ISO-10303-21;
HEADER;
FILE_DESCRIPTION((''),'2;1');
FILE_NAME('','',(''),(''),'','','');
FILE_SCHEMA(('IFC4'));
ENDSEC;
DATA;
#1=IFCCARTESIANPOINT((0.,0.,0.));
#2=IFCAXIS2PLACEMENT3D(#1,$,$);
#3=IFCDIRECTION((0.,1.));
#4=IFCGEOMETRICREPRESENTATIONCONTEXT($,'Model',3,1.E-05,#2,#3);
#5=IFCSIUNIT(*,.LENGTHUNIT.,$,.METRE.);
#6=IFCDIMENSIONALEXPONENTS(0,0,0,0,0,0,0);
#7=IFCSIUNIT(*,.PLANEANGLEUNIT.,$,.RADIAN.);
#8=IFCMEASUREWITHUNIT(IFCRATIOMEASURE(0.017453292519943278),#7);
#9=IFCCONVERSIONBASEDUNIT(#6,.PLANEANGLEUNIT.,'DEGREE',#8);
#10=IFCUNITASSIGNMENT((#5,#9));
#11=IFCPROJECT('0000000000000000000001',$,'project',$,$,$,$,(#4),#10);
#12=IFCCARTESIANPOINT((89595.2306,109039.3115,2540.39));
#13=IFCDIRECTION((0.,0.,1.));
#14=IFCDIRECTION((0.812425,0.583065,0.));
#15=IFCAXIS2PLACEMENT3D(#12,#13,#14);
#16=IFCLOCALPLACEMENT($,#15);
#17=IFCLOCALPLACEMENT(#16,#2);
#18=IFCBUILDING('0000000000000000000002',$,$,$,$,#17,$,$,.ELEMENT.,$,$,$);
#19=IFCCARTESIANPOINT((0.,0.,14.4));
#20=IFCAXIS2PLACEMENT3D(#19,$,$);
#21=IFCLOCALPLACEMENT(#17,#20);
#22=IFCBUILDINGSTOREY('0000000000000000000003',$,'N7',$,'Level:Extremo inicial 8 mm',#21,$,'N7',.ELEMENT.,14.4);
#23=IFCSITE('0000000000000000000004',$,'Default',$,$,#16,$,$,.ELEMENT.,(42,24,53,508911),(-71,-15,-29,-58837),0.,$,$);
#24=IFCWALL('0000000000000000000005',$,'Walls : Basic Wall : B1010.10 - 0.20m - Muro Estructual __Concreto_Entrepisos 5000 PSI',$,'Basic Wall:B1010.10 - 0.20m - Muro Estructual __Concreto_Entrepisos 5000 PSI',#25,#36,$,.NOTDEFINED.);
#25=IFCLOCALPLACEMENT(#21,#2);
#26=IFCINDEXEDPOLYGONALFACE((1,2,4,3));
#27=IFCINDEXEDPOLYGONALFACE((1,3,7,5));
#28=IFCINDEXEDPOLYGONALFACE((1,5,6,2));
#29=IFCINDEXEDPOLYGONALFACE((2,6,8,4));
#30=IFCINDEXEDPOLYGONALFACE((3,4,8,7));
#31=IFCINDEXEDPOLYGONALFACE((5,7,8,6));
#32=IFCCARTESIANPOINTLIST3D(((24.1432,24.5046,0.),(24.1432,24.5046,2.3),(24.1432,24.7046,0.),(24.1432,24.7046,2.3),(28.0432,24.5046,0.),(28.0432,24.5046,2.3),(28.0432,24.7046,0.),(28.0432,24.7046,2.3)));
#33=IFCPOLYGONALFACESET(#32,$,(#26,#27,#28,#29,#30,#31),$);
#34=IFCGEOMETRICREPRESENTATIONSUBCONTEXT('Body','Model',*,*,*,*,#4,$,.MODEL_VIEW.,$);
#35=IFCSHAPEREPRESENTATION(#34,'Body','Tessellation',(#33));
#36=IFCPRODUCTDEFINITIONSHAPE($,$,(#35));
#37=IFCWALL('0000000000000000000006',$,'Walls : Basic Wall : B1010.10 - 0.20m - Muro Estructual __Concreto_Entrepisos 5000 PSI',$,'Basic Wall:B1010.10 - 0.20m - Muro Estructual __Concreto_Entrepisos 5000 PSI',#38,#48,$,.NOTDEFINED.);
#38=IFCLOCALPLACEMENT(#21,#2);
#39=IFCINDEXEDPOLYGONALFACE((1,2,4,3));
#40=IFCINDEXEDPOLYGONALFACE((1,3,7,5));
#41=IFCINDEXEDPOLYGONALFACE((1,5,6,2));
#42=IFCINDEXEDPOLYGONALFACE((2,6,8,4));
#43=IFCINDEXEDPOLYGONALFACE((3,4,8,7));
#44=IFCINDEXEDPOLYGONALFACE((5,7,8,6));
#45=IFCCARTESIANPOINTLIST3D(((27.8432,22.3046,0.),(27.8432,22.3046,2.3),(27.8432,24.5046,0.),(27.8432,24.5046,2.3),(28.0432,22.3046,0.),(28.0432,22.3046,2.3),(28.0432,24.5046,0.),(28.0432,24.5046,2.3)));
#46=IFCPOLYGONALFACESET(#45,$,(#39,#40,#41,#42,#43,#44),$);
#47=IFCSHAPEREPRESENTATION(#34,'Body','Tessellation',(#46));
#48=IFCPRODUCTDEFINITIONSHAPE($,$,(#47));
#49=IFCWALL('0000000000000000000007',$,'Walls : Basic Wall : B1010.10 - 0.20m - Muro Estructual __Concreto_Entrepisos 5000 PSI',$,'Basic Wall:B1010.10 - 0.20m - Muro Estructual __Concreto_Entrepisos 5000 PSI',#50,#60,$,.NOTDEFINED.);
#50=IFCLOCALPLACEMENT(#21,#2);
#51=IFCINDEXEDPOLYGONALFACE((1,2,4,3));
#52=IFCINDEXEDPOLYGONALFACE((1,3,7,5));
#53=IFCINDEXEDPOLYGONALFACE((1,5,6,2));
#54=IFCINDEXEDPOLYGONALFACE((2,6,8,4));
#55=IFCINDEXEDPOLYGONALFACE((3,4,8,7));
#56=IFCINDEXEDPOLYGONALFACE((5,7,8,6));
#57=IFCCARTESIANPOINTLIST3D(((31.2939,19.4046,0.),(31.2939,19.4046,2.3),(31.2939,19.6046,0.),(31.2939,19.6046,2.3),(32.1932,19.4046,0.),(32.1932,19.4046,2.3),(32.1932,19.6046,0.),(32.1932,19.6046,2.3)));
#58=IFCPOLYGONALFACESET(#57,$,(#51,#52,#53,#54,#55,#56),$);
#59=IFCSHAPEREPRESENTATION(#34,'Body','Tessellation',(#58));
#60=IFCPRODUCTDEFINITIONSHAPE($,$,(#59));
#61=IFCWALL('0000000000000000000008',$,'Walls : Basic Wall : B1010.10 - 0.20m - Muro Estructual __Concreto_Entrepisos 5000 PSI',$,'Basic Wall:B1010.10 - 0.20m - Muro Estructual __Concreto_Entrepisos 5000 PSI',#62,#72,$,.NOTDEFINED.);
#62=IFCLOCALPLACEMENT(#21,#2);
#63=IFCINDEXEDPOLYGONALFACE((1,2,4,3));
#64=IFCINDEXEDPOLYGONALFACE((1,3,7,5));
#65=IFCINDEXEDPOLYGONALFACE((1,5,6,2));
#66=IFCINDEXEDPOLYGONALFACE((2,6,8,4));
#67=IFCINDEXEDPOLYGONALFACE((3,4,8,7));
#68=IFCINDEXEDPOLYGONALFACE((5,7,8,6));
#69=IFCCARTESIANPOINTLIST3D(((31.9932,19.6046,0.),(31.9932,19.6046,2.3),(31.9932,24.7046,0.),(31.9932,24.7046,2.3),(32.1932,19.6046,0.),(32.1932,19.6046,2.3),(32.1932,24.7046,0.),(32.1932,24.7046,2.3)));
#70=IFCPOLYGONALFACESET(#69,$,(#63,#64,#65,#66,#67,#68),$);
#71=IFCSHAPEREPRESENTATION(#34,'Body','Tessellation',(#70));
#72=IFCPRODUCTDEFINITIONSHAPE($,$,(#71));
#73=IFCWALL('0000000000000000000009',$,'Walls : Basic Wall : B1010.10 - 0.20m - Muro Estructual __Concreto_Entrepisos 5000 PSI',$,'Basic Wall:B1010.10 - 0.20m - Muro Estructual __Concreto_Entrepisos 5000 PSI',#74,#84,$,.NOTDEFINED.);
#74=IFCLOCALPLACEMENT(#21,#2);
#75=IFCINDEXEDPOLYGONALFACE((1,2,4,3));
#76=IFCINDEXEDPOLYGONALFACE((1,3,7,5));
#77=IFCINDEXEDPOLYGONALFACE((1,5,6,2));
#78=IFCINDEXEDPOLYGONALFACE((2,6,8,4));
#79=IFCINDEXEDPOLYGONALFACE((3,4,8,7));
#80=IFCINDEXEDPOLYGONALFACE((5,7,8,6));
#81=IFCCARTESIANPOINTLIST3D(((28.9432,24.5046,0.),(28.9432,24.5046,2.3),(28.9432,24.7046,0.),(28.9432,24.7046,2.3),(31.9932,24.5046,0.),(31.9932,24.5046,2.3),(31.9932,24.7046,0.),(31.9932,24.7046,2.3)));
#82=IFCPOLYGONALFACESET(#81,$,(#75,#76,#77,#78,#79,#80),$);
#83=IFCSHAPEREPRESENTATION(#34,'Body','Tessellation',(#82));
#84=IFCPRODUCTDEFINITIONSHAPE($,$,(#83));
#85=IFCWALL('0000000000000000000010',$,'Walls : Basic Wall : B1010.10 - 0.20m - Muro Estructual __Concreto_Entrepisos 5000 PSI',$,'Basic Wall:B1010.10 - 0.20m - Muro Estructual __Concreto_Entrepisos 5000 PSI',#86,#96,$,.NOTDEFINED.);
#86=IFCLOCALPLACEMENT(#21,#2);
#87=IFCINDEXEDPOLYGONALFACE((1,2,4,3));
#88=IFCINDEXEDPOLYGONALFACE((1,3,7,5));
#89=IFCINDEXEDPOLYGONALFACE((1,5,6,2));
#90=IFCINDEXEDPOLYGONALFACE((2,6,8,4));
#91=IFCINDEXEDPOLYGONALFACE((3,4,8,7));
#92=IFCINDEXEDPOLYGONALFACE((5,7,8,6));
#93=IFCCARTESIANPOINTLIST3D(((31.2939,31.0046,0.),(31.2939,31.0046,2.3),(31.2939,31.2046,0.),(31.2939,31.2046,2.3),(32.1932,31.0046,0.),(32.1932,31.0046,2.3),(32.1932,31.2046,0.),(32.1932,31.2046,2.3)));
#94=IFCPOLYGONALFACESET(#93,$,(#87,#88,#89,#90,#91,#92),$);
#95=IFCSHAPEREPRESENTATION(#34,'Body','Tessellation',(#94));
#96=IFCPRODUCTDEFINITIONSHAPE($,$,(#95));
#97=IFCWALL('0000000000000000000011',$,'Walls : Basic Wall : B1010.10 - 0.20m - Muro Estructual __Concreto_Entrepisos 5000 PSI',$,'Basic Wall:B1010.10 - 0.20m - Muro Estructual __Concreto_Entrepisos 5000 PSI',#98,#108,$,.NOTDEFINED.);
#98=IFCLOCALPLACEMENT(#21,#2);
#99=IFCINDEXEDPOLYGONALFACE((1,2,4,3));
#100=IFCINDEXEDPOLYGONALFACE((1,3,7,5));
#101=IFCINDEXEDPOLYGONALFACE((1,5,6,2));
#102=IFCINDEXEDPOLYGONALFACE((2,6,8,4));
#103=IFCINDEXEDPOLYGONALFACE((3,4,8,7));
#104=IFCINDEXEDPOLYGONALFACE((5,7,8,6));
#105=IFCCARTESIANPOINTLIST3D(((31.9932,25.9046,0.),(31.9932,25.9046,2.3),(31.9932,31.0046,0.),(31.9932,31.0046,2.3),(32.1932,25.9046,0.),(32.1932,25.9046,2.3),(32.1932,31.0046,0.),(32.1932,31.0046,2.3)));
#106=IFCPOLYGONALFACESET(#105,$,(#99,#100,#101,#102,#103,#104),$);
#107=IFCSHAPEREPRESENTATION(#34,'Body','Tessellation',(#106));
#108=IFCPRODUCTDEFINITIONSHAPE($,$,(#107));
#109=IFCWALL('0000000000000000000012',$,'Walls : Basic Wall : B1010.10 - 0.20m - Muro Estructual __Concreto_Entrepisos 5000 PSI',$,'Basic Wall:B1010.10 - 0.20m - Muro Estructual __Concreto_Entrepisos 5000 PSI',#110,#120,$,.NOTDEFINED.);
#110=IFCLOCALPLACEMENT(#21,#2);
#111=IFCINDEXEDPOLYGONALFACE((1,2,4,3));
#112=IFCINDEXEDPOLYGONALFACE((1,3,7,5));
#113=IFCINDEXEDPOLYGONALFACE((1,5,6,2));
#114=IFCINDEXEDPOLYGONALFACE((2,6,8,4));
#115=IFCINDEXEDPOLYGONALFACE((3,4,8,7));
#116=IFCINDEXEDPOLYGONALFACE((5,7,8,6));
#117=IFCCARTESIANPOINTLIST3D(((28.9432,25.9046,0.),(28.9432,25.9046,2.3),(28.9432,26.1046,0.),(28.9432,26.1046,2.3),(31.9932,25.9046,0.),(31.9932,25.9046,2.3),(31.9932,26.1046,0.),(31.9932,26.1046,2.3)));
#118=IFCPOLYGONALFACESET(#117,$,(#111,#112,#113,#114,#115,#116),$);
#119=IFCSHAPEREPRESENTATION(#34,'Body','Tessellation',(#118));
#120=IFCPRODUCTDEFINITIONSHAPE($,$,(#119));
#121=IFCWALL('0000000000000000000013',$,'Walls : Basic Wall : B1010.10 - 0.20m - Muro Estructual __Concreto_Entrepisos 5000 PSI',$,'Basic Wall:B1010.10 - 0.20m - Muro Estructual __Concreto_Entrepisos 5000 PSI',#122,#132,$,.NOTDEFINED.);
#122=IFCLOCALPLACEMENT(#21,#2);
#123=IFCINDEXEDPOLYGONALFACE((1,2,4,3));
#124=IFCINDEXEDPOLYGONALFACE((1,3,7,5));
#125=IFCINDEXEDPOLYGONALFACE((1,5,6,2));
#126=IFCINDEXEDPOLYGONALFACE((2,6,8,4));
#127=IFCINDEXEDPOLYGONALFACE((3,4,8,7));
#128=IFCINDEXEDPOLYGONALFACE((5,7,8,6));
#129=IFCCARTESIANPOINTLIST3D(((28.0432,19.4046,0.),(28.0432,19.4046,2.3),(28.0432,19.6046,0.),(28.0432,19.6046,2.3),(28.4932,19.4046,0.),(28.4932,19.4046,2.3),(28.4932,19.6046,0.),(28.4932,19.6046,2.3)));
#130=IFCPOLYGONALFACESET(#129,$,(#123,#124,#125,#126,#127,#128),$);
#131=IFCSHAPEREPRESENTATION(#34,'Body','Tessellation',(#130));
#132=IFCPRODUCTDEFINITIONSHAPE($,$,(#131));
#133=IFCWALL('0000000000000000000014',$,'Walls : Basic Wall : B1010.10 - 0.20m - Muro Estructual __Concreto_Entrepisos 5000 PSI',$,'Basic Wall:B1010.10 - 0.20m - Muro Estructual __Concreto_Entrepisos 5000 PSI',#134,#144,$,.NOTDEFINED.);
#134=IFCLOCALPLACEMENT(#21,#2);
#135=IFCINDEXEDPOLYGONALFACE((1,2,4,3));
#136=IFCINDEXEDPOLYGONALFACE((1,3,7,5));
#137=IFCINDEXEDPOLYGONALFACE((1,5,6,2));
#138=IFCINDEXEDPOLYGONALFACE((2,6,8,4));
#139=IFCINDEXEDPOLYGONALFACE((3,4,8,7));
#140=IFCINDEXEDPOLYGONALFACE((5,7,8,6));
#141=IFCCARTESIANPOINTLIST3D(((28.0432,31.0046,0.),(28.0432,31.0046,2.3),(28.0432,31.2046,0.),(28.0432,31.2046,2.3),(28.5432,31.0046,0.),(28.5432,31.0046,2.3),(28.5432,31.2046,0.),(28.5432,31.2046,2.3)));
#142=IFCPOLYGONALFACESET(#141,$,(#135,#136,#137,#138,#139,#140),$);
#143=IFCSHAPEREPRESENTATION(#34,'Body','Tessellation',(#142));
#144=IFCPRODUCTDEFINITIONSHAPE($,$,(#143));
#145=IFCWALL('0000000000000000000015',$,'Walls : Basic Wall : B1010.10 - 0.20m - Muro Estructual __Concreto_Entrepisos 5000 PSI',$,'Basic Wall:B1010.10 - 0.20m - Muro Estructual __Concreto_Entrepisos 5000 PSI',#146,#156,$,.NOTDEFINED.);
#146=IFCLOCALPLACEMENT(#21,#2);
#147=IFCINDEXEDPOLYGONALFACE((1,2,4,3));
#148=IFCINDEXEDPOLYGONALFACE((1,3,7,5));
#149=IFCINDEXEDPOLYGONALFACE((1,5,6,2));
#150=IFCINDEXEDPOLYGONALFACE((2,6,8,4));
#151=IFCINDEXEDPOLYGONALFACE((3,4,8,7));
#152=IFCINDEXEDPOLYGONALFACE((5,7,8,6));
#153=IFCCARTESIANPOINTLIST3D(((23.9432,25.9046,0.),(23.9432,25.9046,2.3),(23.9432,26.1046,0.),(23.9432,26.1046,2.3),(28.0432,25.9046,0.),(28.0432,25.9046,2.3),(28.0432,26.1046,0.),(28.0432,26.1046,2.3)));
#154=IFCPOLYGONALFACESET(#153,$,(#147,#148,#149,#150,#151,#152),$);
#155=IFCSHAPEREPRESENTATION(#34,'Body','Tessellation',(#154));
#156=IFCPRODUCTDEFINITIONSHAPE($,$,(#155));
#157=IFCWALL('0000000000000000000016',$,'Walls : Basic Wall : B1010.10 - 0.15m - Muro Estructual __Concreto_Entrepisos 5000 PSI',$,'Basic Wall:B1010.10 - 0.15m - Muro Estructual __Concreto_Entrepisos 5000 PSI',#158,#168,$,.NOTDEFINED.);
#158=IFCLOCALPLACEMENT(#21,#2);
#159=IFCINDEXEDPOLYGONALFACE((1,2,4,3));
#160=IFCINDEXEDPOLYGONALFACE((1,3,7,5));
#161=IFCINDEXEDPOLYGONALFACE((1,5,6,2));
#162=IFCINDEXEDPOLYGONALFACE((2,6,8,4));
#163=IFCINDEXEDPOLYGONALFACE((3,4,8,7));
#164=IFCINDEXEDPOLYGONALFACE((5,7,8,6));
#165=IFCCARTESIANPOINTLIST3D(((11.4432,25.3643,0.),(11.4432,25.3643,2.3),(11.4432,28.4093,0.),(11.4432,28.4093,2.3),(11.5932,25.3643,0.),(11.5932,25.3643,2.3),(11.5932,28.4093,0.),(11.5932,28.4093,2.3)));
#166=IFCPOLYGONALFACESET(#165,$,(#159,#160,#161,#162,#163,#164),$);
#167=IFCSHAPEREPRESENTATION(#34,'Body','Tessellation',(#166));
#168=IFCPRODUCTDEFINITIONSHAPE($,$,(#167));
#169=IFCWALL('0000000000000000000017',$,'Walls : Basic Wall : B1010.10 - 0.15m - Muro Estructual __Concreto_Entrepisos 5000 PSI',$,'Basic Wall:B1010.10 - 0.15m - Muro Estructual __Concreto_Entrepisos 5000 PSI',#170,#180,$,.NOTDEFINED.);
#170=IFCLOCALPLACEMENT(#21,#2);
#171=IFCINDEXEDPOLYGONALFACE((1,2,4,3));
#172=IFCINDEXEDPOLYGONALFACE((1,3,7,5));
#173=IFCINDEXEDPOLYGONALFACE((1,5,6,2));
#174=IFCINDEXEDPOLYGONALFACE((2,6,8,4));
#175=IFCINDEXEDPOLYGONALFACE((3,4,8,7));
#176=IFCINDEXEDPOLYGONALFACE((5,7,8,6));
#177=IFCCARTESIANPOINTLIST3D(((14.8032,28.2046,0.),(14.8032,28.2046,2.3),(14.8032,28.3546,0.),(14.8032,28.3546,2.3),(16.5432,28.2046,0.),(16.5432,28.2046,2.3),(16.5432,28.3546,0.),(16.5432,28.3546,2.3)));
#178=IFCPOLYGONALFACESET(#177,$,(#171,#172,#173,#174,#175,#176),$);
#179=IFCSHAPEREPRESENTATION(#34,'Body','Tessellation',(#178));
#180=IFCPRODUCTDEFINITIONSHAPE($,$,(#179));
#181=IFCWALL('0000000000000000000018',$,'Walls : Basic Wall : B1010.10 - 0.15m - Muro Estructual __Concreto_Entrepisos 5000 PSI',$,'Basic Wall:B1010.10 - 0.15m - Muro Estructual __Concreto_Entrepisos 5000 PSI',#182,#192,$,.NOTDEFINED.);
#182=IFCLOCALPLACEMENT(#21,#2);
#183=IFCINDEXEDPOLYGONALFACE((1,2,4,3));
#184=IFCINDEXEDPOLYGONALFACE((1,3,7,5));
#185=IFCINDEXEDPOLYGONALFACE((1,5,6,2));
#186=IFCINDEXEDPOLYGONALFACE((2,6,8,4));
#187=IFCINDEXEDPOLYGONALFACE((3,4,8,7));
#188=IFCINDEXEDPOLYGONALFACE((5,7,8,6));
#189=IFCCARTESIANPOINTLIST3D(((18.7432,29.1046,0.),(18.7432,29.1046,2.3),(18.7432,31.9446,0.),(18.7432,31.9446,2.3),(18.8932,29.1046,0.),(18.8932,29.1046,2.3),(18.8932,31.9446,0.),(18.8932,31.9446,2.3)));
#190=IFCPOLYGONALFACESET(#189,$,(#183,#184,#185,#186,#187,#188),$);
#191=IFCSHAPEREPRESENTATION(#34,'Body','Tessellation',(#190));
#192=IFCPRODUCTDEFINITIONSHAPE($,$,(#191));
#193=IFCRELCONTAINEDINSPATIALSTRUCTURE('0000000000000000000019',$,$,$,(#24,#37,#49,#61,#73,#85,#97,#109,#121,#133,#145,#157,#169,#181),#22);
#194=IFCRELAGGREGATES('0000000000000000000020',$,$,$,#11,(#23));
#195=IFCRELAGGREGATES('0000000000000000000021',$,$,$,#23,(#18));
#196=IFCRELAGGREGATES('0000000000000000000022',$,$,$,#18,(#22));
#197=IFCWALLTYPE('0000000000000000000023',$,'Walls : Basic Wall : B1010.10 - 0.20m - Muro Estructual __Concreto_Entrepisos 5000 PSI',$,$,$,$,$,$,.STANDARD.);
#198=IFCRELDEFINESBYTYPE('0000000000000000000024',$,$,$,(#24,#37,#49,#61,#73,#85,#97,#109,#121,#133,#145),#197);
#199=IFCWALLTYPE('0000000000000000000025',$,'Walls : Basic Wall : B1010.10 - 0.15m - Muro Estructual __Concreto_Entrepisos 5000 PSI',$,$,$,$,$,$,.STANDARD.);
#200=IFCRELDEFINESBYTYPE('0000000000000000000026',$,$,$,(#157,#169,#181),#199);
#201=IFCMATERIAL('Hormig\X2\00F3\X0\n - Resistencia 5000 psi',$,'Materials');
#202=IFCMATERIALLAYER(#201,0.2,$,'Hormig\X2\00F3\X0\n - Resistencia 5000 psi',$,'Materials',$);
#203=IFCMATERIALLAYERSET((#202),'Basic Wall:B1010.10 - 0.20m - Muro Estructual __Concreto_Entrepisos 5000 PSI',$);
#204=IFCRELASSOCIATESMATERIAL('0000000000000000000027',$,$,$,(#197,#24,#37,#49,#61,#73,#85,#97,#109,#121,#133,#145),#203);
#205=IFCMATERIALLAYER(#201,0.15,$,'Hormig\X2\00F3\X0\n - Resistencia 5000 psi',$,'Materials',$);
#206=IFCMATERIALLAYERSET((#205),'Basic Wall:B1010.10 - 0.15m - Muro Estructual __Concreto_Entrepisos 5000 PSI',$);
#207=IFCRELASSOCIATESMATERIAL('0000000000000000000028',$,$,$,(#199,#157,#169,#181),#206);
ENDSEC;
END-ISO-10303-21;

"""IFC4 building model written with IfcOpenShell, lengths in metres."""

from ifc_helpers import new_model, entity, si_unit, converted_unit, direction, frame, frame_2d, origin, place, context, subcontext, project, spatial, rectangle, extrude, material, layer, layer_set, layer_usage, type_object, element, save


model = new_model("IFC4")

# Units and contexts
model_context = context("Model", 3, precision=1e-05, world=origin(), true_north=direction((0.0, 1.0)))
body_context = subcontext(model_context, "Body", "Model", "MODEL_VIEW")
ifc_project = project(units=[si_unit("LENGTHUNIT", "METRE"), converted_unit("PLANEANGLEUNIT", "DEGREE", entity("IfcRatioMeasure", 0.017453292519943278), si_unit("PLANEANGLEUNIT", "RADIAN"), dimensions=[0, 0, 0, 0, 0, 0, 0])], contexts=[model_context])

# Site, building, storey
site_placement = place(None, frame((89595.2306, 109039.3115, 2540.39), z_axis=(0.0, 0.0, 1.0), x_axis=(0.812425, 0.583065, 0.0)))
site = spatial("IfcSite", under=ifc_project, at=site_placement, Name="Default", CompositionType="ELEMENT", RefLatitude=(42, 24, 53, 508911), RefLongitude=(-71, -15, -29, -58837), RefElevation=0.0)
building_placement = place(site_placement, origin())
building = spatial("IfcBuilding", under=site, at=building_placement, CompositionType="ELEMENT")
storey_placement = place(building_placement, frame((0.0, 0.0, 14.4)))
storey = spatial("IfcBuildingStorey", under=building, at=storey_placement, Name="N7", ObjectType="Level:Extremo inicial 8 mm", LongName="N7", CompositionType="ELEMENT", Elevation=14.4)

# Walls
ifc_material_1 = material(Name="Hormigón - Resistencia 5000 psi", Category="Materials")
ifc_layer_1 = layer(ifc_material_1, 0.2, Name="Hormigón - Resistencia 5000 psi", Category="Materials")
ifc_layer_set_1 = layer_set([ifc_layer_1], Name="Basic Wall:B1010.10 - 0.20m - Muro Estructual __Concreto_Entrepisos 5000 PSI")
wall_type_1 = type_object("IfcWallType", Name="Walls : Basic Wall : B1010.10 - 0.20m - Muro Estructual __Concreto_Entrepisos 5000 PSI", PredefinedType="STANDARD", material=ifc_layer_set_1)
ifc_layer_usage_1 = layer_usage(ifc_layer_set_1, "AXIS2", "NEGATIVE", 0.1)
wall_1_placement = place(storey_placement, frame((24.1432, 24.6046, 0.0)))
element("IfcWall", 1, at=wall_1_placement, inside=storey, type_object=wall_type_1, material=ifc_layer_usage_1, Name="Walls : Basic Wall : B1010.10 - 0.20m - Muro Estructual __Concreto_Entrepisos 5000 PSI", ObjectType="Basic Wall:B1010.10 - 0.20m - Muro Estructual __Concreto_Entrepisos 5000 PSI", PredefinedType="NOTDEFINED", context=body_context, shape_type="SweptSolid", body=[
    extrude(rectangle(XDim=3.9, YDim=0.2, at=frame_2d((1.95, 0.0), x_axis=(-1.0, 0.0))), origin(), (0.0, 0.0, 1.0), 2.3),
])
ifc_layer_usage_2 = layer_usage(ifc_layer_set_1, "AXIS2", "NEGATIVE", 0.1)
wall_2_placement = place(storey_placement, frame((27.9432, 24.5046, 0.0), z_axis=(0.0, 0.0, 1.0), x_axis=(0.0, -1.0, 0.0)))
element("IfcWall", 2, at=wall_2_placement, inside=storey, type_object=wall_type_1, material=ifc_layer_usage_2, Name="Walls : Basic Wall : B1010.10 - 0.20m - Muro Estructual __Concreto_Entrepisos 5000 PSI", ObjectType="Basic Wall:B1010.10 - 0.20m - Muro Estructual __Concreto_Entrepisos 5000 PSI", PredefinedType="NOTDEFINED", context=body_context, shape_type="SweptSolid", body=[
    extrude(rectangle(XDim=2.2, YDim=0.2, at=frame_2d((1.1, 0.0), x_axis=(-1.0, 0.0))), origin(), (0.0, 0.0, 1.0), 2.3),
])
ifc_layer_usage_3 = layer_usage(ifc_layer_set_1, "AXIS2", "NEGATIVE", 0.1)
wall_3_placement = place(storey_placement, frame((31.2939, 19.5046, 0.0)))
element("IfcWall", 3, at=wall_3_placement, inside=storey, type_object=wall_type_1, material=ifc_layer_usage_3, Name="Walls : Basic Wall : B1010.10 - 0.20m - Muro Estructual __Concreto_Entrepisos 5000 PSI", ObjectType="Basic Wall:B1010.10 - 0.20m - Muro Estructual __Concreto_Entrepisos 5000 PSI", PredefinedType="NOTDEFINED", context=body_context, shape_type="SweptSolid", body=[
    extrude(rectangle(XDim=0.8993, YDim=0.2, at=frame_2d((0.4497, 0.0), x_axis=(-1.0, 0.0))), origin(), (0.0, 0.0, 1.0), 2.3),
])
ifc_layer_usage_4 = layer_usage(ifc_layer_set_1, "AXIS2", "NEGATIVE", 0.1)
wall_4_placement = place(storey_placement, frame((32.0932, 19.6046, 0.0), z_axis=(0.0, 0.0, 1.0), x_axis=(0.0, 1.0, 0.0)))
element("IfcWall", 4, at=wall_4_placement, inside=storey, type_object=wall_type_1, material=ifc_layer_usage_4, Name="Walls : Basic Wall : B1010.10 - 0.20m - Muro Estructual __Concreto_Entrepisos 5000 PSI", ObjectType="Basic Wall:B1010.10 - 0.20m - Muro Estructual __Concreto_Entrepisos 5000 PSI", PredefinedType="NOTDEFINED", context=body_context, shape_type="SweptSolid", body=[
    extrude(rectangle(XDim=5.1, YDim=0.2, at=frame_2d((2.55, 0.0), x_axis=(-1.0, 0.0))), origin(), (0.0, 0.0, 1.0), 2.3),
])
ifc_layer_usage_5 = layer_usage(ifc_layer_set_1, "AXIS2", "NEGATIVE", 0.1)
wall_5_placement = place(storey_placement, frame((31.9932, 24.6046, 0.0), z_axis=(0.0, 0.0, 1.0), x_axis=(-1.0, 0.0, 0.0)))
element("IfcWall", 5, at=wall_5_placement, inside=storey, type_object=wall_type_1, material=ifc_layer_usage_5, Name="Walls : Basic Wall : B1010.10 - 0.20m - Muro Estructual __Concreto_Entrepisos 5000 PSI", ObjectType="Basic Wall:B1010.10 - 0.20m - Muro Estructual __Concreto_Entrepisos 5000 PSI", PredefinedType="NOTDEFINED", context=body_context, shape_type="SweptSolid", body=[
    extrude(rectangle(XDim=3.05, YDim=0.2, at=frame_2d((1.525, 0.0), x_axis=(-1.0, 0.0))), origin(), (0.0, 0.0, 1.0), 2.3),
])
ifc_layer_usage_6 = layer_usage(ifc_layer_set_1, "AXIS2", "POSITIVE", -0.1)
wall_6_placement = place(storey_placement, frame((31.2939, 31.1046, 0.0)))
element("IfcWall", 6, at=wall_6_placement, inside=storey, type_object=wall_type_1, material=ifc_layer_usage_6, Name="Walls : Basic Wall : B1010.10 - 0.20m - Muro Estructual __Concreto_Entrepisos 5000 PSI", ObjectType="Basic Wall:B1010.10 - 0.20m - Muro Estructual __Concreto_Entrepisos 5000 PSI", PredefinedType="NOTDEFINED", context=body_context, shape_type="SweptSolid", body=[
    extrude(rectangle(XDim=0.8993, YDim=0.2, at=frame_2d((0.4497, 0.0), x_axis=(-1.0, 0.0))), origin(), (0.0, 0.0, 1.0), 2.3),
])
ifc_layer_usage_7 = layer_usage(ifc_layer_set_1, "AXIS2", "POSITIVE", -0.1)
wall_7_placement = place(storey_placement, frame((32.0932, 31.0046, 0.0), z_axis=(0.0, 0.0, 1.0), x_axis=(0.0, -1.0, 0.0)))
element("IfcWall", 7, at=wall_7_placement, inside=storey, type_object=wall_type_1, material=ifc_layer_usage_7, Name="Walls : Basic Wall : B1010.10 - 0.20m - Muro Estructual __Concreto_Entrepisos 5000 PSI", ObjectType="Basic Wall:B1010.10 - 0.20m - Muro Estructual __Concreto_Entrepisos 5000 PSI", PredefinedType="NOTDEFINED", context=body_context, shape_type="SweptSolid", body=[
    extrude(rectangle(XDim=5.1, YDim=0.2, at=frame_2d((2.55, 0.0), x_axis=(-1.0, 0.0))), origin(), (0.0, 0.0, 1.0), 2.3),
])
ifc_layer_usage_8 = layer_usage(ifc_layer_set_1, "AXIS2", "POSITIVE", -0.1)
wall_8_placement = place(storey_placement, frame((31.9932, 26.0046, 0.0), z_axis=(0.0, 0.0, 1.0), x_axis=(-1.0, 0.0, 0.0)))
element("IfcWall", 8, at=wall_8_placement, inside=storey, type_object=wall_type_1, material=ifc_layer_usage_8, Name="Walls : Basic Wall : B1010.10 - 0.20m - Muro Estructual __Concreto_Entrepisos 5000 PSI", ObjectType="Basic Wall:B1010.10 - 0.20m - Muro Estructual __Concreto_Entrepisos 5000 PSI", PredefinedType="NOTDEFINED", context=body_context, shape_type="SweptSolid", body=[
    extrude(rectangle(XDim=3.05, YDim=0.2, at=frame_2d((1.525, 0.0), x_axis=(-1.0, 0.0))), origin(), (0.0, 0.0, 1.0), 2.3),
])
ifc_layer_usage_9 = layer_usage(ifc_layer_set_1, "AXIS2", "NEGATIVE", 0.1)
wall_9_placement = place(storey_placement, frame((28.4932, 19.5046, 0.0), z_axis=(0.0, 0.0, 1.0), x_axis=(-1.0, 0.0, 0.0)))
element("IfcWall", 9, at=wall_9_placement, inside=storey, type_object=wall_type_1, material=ifc_layer_usage_9, Name="Walls : Basic Wall : B1010.10 - 0.20m - Muro Estructual __Concreto_Entrepisos 5000 PSI", ObjectType="Basic Wall:B1010.10 - 0.20m - Muro Estructual __Concreto_Entrepisos 5000 PSI", PredefinedType="NOTDEFINED", context=body_context, shape_type="SweptSolid", body=[
    extrude(rectangle(XDim=0.45, YDim=0.2, at=frame_2d((0.225, 0.0), x_axis=(-1.0, 0.0))), origin(), (0.0, 0.0, 1.0), 2.3),
])
ifc_layer_usage_10 = layer_usage(ifc_layer_set_1, "AXIS2", "NEGATIVE", 0.1)
wall_10_placement = place(storey_placement, frame((28.5432, 31.1046, 0.0), z_axis=(0.0, 0.0, 1.0), x_axis=(-1.0, 0.0, 0.0)))
element("IfcWall", 10, at=wall_10_placement, inside=storey, type_object=wall_type_1, material=ifc_layer_usage_10, Name="Walls : Basic Wall : B1010.10 - 0.20m - Muro Estructual __Concreto_Entrepisos 5000 PSI", ObjectType="Basic Wall:B1010.10 - 0.20m - Muro Estructual __Concreto_Entrepisos 5000 PSI", PredefinedType="NOTDEFINED", context=body_context, shape_type="SweptSolid", body=[
    extrude(rectangle(XDim=0.5, YDim=0.2, at=frame_2d((0.25, 0.0), x_axis=(-1.0, 0.0))), origin(), (0.0, 0.0, 1.0), 2.3),
])
ifc_layer_usage_11 = layer_usage(ifc_layer_set_1, "AXIS2", "NEGATIVE", 0.1)
wall_11_placement = place(storey_placement, frame((23.9432, 26.0046, 0.0)))
element("IfcWall", 11, at=wall_11_placement, inside=storey, type_object=wall_type_1, material=ifc_layer_usage_11, Name="Walls : Basic Wall : B1010.10 - 0.20m - Muro Estructual __Concreto_Entrepisos 5000 PSI", ObjectType="Basic Wall:B1010.10 - 0.20m - Muro Estructual __Concreto_Entrepisos 5000 PSI", PredefinedType="NOTDEFINED", context=body_context, shape_type="SweptSolid", body=[
    extrude(rectangle(XDim=4.1, YDim=0.2, at=frame_2d((2.05, 0.0), x_axis=(-1.0, 0.0))), origin(), (0.0, 0.0, 1.0), 2.3),
])
ifc_layer_2 = layer(ifc_material_1, 0.15, Name="Hormigón - Resistencia 5000 psi", Category="Materials")
ifc_layer_set_2 = layer_set([ifc_layer_2], Name="Basic Wall:B1010.10 - 0.15m - Muro Estructual __Concreto_Entrepisos 5000 PSI")
ifc_layer_usage_12 = layer_usage(ifc_layer_set_2, "AXIS2", "NEGATIVE", 0.075)
wall_type_2 = type_object("IfcWallType", Name="Walls : Basic Wall : B1010.10 - 0.15m - Muro Estructual __Concreto_Entrepisos 5000 PSI", PredefinedType="STANDARD", material=ifc_layer_set_2)
wall_12_placement = place(storey_placement, frame((11.5182, 25.3643, 0.0), z_axis=(0.0, 0.0, 1.0), x_axis=(0.0, 1.0, 0.0)))
element("IfcWall", 12, at=wall_12_placement, inside=storey, type_object=wall_type_2, material=ifc_layer_usage_12, Name="Walls : Basic Wall : B1010.10 - 0.15m - Muro Estructual __Concreto_Entrepisos 5000 PSI", ObjectType="Basic Wall:B1010.10 - 0.15m - Muro Estructual __Concreto_Entrepisos 5000 PSI", PredefinedType="NOTDEFINED", context=body_context, shape_type="SweptSolid", body=[
    extrude(rectangle(XDim=3.045, YDim=0.15, at=frame_2d((1.5225, 0.0), x_axis=(-1.0, 0.0))), origin(), (0.0, 0.0, 1.0), 2.3),
])
ifc_layer_usage_13 = layer_usage(ifc_layer_set_2, "AXIS2", "NEGATIVE", 0.075)
wall_13_placement = place(storey_placement, frame((16.5432, 28.2796, 0.0), z_axis=(0.0, 0.0, 1.0), x_axis=(-1.0, 0.0, 0.0)))
element("IfcWall", 13, at=wall_13_placement, inside=storey, type_object=wall_type_2, material=ifc_layer_usage_13, Name="Walls : Basic Wall : B1010.10 - 0.15m - Muro Estructual __Concreto_Entrepisos 5000 PSI", ObjectType="Basic Wall:B1010.10 - 0.15m - Muro Estructual __Concreto_Entrepisos 5000 PSI", PredefinedType="NOTDEFINED", context=body_context, shape_type="SweptSolid", body=[
    extrude(rectangle(XDim=1.74, YDim=0.15, at=frame_2d((0.87, 0.0), x_axis=(-1.0, 0.0))), origin(), (0.0, 0.0, 1.0), 2.3),
])
ifc_layer_usage_14 = layer_usage(ifc_layer_set_2, "AXIS2", "NEGATIVE", 0.075)
wall_14_placement = place(storey_placement, frame((18.8182, 31.9446, 0.0), z_axis=(0.0, 0.0, 1.0), x_axis=(0.0, -1.0, 0.0)))
element("IfcWall", 14, at=wall_14_placement, inside=storey, type_object=wall_type_2, material=ifc_layer_usage_14, Name="Walls : Basic Wall : B1010.10 - 0.15m - Muro Estructual __Concreto_Entrepisos 5000 PSI", ObjectType="Basic Wall:B1010.10 - 0.15m - Muro Estructual __Concreto_Entrepisos 5000 PSI", PredefinedType="NOTDEFINED", context=body_context, shape_type="SweptSolid", body=[
    extrude(rectangle(XDim=2.84, YDim=0.15, at=frame_2d((1.42, 0.0), x_axis=(-1.0, 0.0))), origin(), (0.0, 0.0, 1.0), 2.3),
])

save(model, "model.ifc")
